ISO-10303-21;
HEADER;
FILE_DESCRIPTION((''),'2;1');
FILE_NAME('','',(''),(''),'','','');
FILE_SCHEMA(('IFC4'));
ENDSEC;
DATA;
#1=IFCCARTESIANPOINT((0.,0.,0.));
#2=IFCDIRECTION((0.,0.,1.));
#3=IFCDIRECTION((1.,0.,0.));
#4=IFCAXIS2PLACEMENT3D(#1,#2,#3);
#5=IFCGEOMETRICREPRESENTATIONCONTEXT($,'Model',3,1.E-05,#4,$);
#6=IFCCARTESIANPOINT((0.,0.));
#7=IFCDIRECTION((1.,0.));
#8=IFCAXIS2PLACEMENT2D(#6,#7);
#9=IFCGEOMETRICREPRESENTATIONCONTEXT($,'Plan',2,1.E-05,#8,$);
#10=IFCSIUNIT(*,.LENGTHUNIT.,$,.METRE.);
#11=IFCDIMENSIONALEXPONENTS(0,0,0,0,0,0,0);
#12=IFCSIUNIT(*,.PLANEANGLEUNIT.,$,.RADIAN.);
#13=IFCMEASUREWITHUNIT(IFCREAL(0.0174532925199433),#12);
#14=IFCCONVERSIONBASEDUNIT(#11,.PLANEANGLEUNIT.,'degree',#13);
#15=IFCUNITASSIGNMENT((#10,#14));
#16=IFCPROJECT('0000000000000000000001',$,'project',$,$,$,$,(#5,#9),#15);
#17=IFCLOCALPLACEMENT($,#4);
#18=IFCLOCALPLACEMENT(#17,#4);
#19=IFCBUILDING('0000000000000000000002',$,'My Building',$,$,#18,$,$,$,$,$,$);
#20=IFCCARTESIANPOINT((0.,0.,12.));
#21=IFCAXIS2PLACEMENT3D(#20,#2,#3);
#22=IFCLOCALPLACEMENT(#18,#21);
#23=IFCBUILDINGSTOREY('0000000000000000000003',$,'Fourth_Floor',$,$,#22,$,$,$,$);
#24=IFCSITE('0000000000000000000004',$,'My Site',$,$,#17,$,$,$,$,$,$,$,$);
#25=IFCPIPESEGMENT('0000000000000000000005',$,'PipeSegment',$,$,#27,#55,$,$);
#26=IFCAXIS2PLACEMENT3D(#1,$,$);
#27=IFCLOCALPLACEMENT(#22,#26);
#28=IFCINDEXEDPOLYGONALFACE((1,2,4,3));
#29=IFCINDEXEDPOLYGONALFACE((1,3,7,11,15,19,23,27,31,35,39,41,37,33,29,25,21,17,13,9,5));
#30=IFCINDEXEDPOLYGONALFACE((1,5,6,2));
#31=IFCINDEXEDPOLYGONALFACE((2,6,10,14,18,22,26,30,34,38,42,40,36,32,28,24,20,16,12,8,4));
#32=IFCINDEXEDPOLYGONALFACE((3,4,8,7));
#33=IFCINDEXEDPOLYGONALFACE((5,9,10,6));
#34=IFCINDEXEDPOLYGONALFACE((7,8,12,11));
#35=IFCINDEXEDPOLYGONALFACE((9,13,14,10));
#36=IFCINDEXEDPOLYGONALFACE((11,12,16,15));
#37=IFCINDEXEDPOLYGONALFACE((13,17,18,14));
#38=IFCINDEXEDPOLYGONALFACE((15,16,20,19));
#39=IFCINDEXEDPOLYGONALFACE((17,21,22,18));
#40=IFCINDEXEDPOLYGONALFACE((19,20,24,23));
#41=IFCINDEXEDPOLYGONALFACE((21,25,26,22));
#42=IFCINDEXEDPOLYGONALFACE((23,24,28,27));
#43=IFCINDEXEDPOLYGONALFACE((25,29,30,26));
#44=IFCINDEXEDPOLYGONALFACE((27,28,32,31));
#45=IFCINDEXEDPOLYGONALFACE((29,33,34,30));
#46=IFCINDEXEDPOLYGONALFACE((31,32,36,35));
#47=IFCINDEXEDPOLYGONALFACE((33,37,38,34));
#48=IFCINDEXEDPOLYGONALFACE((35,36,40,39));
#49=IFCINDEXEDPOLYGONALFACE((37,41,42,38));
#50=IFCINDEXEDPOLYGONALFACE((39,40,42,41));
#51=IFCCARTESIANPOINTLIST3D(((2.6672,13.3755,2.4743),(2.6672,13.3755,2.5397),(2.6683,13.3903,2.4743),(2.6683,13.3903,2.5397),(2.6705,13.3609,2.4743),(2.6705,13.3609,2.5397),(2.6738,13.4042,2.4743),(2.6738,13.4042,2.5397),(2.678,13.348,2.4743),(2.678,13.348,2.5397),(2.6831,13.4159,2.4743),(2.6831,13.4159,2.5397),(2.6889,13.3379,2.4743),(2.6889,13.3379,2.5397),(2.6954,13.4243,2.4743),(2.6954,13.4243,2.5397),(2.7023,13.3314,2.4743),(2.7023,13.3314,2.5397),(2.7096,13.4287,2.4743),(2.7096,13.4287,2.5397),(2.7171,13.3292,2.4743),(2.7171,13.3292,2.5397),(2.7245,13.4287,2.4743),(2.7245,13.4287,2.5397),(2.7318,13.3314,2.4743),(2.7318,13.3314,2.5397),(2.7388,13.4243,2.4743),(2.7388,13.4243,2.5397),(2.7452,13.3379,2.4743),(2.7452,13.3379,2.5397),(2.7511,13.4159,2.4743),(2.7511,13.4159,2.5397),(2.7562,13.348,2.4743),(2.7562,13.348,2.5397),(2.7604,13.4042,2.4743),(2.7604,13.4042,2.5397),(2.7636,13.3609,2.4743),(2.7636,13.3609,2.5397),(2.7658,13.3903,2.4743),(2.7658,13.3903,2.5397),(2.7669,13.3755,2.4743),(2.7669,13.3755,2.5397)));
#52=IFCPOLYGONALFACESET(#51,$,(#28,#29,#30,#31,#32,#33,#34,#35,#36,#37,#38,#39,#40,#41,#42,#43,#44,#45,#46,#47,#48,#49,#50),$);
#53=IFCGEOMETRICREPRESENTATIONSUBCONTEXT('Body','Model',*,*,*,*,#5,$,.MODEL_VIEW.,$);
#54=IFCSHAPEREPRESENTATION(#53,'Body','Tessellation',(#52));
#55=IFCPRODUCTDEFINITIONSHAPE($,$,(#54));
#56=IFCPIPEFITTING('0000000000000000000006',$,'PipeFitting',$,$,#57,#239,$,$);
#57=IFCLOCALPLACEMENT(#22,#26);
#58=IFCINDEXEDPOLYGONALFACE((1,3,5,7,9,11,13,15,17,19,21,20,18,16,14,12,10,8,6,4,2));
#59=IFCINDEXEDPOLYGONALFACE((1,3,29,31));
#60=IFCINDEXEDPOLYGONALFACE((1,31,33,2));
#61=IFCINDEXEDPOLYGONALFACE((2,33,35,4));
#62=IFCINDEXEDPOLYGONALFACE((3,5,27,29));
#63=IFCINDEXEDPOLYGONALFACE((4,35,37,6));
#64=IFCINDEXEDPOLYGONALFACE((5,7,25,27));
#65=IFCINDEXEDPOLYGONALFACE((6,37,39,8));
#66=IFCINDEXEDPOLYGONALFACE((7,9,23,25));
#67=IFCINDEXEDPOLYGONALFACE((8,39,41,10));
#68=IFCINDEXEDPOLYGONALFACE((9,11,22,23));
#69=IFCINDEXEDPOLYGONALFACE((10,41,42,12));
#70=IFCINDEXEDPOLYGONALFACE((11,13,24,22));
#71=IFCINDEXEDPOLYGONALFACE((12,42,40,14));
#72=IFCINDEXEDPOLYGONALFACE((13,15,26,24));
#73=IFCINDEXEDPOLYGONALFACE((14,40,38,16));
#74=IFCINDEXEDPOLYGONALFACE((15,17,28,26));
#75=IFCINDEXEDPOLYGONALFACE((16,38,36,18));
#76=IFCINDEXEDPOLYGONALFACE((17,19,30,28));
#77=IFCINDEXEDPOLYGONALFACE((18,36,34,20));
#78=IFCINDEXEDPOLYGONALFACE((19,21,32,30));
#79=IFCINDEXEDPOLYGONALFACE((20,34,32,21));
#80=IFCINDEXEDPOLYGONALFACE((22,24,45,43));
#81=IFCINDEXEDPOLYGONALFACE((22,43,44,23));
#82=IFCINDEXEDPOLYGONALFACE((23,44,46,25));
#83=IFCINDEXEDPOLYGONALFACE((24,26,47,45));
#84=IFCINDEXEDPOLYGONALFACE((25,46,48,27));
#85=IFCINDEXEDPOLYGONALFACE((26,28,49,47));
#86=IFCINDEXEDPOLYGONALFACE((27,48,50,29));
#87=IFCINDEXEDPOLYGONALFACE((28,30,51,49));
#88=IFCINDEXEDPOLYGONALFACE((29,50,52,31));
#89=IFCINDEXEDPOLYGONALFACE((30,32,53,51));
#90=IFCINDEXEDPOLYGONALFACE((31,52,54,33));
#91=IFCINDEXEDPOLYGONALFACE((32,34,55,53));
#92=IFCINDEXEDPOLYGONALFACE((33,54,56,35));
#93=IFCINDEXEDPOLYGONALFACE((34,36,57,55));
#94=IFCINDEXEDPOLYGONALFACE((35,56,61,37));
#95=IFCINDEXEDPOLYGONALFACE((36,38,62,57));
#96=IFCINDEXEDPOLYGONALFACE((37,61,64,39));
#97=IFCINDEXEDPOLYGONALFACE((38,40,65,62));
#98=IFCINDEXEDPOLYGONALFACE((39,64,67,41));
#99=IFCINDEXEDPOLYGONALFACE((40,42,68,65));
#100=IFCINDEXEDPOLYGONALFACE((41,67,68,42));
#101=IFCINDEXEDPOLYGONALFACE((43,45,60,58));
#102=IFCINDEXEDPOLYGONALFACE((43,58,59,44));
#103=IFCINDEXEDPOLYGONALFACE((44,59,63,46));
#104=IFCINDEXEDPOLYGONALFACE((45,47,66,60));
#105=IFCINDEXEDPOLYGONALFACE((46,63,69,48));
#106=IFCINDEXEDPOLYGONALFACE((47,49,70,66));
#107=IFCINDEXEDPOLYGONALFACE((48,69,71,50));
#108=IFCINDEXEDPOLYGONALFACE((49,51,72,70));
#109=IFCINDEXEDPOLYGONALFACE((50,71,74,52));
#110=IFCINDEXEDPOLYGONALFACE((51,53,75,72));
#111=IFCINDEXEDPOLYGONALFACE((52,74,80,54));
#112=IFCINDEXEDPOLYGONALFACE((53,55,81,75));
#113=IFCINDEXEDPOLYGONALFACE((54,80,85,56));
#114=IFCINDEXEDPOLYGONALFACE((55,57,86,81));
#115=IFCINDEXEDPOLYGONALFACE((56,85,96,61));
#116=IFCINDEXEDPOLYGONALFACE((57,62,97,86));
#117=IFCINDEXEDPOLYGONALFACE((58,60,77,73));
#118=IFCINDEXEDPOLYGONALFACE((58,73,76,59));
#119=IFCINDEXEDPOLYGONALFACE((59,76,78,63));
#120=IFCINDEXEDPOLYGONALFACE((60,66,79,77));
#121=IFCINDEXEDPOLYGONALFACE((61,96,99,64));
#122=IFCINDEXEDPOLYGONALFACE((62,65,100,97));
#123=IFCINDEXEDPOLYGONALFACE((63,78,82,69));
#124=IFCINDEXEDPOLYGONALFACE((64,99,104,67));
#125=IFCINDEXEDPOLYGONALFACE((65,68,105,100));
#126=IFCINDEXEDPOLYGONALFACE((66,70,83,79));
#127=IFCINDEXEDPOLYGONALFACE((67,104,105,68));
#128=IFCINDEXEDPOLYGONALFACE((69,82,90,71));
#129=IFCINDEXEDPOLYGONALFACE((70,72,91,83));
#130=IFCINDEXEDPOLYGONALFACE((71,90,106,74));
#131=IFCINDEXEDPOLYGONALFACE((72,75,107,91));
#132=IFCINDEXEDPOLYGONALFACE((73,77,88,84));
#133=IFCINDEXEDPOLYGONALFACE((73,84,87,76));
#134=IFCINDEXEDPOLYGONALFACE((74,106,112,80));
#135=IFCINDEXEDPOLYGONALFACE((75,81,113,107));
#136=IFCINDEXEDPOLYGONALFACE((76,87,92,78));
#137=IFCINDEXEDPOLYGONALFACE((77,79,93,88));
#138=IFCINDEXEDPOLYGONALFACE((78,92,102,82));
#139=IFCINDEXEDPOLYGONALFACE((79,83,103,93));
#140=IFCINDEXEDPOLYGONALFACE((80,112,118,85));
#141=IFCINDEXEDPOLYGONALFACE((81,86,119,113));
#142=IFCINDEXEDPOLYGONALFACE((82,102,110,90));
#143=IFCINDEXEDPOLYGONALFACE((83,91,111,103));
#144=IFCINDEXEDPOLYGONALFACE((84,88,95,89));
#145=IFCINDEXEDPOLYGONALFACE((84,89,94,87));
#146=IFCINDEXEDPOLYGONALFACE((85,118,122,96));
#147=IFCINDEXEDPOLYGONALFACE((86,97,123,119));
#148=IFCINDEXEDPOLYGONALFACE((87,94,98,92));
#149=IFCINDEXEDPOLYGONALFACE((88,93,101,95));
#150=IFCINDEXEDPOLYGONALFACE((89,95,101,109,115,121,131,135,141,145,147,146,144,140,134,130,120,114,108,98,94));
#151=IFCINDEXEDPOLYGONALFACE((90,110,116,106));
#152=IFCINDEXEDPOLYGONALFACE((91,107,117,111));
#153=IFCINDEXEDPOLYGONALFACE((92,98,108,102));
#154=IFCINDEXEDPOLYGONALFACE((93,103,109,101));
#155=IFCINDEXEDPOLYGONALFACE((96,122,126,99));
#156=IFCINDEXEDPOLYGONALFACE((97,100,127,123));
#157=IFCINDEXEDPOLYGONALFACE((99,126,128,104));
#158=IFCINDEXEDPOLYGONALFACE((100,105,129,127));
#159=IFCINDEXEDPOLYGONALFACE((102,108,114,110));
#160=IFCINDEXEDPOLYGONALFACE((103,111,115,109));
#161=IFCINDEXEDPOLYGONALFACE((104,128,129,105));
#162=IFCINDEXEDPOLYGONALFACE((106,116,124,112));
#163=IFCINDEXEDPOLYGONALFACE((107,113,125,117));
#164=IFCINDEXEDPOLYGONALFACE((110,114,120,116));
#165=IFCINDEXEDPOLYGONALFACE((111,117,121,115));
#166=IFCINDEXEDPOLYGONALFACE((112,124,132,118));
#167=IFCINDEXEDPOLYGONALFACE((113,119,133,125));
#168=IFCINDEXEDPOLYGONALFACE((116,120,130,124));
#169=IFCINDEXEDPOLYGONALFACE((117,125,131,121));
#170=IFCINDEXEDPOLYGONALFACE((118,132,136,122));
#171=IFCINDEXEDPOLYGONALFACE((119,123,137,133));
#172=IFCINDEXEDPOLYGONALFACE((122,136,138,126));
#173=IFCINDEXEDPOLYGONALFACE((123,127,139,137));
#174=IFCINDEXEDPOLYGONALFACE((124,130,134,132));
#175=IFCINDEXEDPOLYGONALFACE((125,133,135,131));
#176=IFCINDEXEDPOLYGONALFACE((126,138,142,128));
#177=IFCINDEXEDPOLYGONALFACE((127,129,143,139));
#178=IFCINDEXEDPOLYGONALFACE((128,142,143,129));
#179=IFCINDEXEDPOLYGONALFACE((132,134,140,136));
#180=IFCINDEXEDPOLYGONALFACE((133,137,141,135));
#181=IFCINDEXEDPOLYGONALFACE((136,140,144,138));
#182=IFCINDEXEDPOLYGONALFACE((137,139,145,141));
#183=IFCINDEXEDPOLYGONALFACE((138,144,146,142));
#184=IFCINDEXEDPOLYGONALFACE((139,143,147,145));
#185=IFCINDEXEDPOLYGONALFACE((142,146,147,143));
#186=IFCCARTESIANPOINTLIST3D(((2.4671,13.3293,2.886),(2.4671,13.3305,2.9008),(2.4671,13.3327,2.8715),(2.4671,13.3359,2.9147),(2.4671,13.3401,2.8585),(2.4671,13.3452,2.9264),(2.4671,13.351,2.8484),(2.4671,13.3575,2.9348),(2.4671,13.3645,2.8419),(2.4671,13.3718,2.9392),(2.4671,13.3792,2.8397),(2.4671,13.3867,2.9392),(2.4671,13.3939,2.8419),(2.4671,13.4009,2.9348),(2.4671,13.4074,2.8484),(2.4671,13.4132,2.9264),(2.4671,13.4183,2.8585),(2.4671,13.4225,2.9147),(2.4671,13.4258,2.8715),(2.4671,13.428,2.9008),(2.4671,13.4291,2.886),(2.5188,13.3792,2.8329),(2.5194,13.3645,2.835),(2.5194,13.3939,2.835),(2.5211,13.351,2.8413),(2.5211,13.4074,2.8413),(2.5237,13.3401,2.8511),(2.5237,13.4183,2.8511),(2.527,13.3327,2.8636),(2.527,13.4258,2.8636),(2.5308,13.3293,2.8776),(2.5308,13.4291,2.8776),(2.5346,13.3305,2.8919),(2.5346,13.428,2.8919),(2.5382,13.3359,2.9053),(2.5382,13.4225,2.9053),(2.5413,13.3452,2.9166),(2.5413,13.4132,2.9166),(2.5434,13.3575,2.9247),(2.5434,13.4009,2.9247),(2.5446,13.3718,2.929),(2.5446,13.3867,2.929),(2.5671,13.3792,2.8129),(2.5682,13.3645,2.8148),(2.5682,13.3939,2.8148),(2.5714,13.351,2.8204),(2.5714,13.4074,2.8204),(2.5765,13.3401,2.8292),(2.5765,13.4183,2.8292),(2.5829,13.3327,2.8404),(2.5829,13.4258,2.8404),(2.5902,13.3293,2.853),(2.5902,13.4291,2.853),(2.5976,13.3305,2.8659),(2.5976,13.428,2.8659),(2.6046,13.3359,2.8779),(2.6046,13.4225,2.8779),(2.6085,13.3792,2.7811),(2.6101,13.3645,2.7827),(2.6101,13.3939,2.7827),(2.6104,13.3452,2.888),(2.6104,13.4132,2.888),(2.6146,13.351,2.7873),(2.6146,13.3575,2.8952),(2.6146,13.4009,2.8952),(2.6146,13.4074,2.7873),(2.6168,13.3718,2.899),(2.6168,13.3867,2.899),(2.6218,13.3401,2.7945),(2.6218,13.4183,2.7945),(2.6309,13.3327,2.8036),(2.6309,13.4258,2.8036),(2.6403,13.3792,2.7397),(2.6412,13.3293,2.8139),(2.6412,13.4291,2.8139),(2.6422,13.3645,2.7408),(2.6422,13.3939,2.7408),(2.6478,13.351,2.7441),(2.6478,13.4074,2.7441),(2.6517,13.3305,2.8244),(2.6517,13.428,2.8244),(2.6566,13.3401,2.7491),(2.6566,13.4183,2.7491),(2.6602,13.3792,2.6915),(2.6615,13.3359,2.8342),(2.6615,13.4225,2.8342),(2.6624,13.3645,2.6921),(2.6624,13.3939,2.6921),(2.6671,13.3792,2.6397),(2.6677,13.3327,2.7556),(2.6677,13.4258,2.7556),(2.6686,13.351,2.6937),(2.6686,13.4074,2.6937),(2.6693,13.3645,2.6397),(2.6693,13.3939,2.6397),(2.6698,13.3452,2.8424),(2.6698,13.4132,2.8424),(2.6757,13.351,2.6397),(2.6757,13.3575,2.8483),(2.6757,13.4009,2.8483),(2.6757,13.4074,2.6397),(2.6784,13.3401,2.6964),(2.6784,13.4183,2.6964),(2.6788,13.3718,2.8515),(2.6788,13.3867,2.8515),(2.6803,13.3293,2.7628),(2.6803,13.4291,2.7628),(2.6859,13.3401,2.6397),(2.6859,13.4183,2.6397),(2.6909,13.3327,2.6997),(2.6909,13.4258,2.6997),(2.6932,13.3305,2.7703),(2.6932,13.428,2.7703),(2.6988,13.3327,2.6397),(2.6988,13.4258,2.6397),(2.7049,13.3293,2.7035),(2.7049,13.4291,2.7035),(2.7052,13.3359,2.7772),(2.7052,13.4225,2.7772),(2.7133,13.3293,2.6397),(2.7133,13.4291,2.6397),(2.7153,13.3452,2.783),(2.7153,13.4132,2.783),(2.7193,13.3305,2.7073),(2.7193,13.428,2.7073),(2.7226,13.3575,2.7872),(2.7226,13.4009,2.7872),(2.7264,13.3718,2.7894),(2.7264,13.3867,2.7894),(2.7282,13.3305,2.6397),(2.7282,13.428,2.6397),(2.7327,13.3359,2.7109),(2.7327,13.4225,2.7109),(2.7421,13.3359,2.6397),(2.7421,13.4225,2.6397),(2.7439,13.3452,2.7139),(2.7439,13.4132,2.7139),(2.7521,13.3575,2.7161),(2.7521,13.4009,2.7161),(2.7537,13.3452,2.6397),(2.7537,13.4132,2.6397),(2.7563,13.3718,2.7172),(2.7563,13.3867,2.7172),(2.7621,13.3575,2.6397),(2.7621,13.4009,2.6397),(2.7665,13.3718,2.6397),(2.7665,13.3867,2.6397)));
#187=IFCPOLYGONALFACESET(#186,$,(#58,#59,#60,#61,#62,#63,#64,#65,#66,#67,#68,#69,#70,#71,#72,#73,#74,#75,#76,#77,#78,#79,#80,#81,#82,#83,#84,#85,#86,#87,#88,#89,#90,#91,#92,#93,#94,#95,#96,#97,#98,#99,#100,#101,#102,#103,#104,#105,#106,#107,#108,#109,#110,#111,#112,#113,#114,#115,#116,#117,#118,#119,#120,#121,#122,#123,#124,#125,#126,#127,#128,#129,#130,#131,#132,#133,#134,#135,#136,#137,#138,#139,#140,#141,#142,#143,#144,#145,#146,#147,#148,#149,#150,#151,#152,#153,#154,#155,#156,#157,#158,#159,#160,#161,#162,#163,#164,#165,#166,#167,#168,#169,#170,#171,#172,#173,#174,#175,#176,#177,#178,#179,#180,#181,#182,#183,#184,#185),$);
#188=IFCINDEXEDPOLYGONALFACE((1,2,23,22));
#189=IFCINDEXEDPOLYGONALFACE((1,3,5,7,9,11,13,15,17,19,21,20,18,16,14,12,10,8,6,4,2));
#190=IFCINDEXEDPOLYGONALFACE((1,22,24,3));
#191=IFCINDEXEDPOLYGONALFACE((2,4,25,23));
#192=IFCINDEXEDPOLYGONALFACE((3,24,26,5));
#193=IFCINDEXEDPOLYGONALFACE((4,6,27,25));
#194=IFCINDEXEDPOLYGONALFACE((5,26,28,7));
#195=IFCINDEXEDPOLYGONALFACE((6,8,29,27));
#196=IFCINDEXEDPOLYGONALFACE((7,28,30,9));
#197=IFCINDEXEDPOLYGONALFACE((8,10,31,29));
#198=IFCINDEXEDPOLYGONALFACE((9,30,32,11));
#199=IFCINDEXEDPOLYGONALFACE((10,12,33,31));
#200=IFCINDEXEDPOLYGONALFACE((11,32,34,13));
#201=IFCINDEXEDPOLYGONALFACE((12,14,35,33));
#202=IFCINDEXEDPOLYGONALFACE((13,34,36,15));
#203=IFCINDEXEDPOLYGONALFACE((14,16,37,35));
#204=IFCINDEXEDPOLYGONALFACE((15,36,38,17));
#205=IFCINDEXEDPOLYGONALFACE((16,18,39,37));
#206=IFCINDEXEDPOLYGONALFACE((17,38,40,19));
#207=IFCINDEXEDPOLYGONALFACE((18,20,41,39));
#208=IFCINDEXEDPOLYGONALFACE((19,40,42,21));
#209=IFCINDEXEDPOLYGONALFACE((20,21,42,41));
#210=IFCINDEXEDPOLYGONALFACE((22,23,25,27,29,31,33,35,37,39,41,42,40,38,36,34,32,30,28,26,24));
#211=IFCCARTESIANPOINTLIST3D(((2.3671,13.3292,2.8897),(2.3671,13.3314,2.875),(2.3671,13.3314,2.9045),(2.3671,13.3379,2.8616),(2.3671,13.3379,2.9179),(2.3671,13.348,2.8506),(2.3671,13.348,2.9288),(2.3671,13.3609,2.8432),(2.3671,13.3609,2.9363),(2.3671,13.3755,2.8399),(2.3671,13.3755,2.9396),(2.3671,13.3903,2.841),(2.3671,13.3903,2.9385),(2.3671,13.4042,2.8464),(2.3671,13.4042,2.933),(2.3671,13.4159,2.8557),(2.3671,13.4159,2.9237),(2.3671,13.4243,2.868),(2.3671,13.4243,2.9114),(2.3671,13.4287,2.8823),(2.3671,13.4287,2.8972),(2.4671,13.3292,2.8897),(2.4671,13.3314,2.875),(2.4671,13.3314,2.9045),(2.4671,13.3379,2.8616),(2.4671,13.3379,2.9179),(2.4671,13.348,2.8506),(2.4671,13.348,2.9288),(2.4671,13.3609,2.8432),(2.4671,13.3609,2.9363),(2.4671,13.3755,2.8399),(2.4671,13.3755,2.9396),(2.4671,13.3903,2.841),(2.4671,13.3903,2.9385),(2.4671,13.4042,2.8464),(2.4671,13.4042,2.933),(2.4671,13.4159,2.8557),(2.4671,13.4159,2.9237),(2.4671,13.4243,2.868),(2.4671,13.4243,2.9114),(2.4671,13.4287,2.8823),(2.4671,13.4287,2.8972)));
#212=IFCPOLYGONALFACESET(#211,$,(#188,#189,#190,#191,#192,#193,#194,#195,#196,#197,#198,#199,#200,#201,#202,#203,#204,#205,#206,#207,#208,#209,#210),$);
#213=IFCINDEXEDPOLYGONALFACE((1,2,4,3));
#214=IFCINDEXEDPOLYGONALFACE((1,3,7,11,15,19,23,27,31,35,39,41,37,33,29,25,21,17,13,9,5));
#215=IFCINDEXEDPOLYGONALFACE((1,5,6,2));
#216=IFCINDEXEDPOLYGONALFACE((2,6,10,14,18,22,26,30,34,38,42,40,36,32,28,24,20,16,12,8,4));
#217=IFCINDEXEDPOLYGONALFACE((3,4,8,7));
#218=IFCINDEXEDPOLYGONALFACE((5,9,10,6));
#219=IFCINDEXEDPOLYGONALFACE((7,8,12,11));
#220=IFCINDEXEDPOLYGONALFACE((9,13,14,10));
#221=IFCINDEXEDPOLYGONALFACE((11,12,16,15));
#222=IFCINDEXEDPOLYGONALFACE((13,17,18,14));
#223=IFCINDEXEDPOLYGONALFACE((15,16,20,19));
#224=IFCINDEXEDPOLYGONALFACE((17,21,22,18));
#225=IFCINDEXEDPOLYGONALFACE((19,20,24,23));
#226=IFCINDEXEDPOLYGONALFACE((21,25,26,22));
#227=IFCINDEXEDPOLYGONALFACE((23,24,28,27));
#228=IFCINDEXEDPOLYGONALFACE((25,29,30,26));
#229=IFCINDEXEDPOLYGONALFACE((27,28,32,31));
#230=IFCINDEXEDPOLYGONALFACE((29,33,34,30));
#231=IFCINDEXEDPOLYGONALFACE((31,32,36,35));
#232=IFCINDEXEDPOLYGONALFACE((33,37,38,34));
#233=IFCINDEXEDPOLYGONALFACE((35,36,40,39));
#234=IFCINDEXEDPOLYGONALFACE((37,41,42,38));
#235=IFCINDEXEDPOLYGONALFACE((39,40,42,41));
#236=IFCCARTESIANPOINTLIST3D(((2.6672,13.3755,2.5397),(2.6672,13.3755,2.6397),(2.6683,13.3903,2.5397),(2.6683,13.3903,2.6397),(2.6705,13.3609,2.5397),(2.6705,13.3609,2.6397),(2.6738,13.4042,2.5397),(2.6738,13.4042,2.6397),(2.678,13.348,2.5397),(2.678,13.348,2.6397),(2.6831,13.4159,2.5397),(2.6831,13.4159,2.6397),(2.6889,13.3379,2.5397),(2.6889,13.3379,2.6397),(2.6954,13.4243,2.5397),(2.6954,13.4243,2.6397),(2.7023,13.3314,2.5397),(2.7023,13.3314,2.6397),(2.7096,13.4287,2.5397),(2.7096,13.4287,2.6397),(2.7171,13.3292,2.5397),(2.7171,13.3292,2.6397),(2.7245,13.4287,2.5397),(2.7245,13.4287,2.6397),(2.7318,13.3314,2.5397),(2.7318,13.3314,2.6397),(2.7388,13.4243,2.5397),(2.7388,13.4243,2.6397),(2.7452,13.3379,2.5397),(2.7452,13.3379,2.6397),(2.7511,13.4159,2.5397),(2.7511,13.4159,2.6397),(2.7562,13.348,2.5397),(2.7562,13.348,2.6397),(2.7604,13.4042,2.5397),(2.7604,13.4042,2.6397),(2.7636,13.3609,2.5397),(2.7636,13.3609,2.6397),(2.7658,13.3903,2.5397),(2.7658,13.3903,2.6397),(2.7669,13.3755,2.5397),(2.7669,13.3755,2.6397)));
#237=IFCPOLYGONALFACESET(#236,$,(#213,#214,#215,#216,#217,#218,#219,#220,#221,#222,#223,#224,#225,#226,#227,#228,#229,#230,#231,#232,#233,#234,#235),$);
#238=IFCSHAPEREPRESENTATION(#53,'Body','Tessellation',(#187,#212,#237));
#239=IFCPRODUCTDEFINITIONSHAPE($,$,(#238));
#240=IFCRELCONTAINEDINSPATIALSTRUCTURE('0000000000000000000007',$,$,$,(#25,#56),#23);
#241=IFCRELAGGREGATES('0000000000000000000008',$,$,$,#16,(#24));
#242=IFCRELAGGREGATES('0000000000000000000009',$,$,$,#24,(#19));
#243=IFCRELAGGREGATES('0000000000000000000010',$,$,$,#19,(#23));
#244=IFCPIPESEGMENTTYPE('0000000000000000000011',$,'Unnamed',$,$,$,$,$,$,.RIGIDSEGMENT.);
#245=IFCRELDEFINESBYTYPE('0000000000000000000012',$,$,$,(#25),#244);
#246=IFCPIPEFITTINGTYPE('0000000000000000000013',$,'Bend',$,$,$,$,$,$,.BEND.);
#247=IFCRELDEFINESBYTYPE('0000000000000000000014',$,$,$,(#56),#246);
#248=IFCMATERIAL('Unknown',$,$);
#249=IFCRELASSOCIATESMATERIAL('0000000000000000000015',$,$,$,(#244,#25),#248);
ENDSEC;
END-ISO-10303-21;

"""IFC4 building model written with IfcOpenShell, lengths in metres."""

from ifc_helpers import new_model, entity, si_unit, converted_unit, frame, origin_with_axes, origin_2d_with_axis, place, context, subcontext, project, spatial, circle, extrude, source, transform, mapped, material, material_profile, profile_set, profile_usage, type_object, type_shapes, element, save


model = new_model("IFC4")

# Units and contexts
model_context = context("Model", 3, precision=1e-05, world=origin_with_axes())
plan_context = context("Plan", 2, precision=1e-05, world=origin_2d_with_axis())
body_context_1 = subcontext(model_context, "Body", "Model", "MODEL_VIEW")
ifc_project = project(units=[si_unit("LENGTHUNIT", "METRE"), converted_unit("PLANEANGLEUNIT", "degree", entity("IfcReal", 0.0174532925199433), si_unit("PLANEANGLEUNIT", "RADIAN"), dimensions=[0, 0, 0, 0, 0, 0, 0])], contexts=[model_context, plan_context])

# Site, building, storey
site_placement = place(None, origin_with_axes())
site = spatial("IfcSite", under=ifc_project, at=site_placement, Name="My Site")
building_placement = place(site_placement, origin_with_axes())
building = spatial("IfcBuilding", under=site, at=building_placement, Name="My Building")
storey_placement = place(building_placement, frame((0.0, 0.0, 12.0), z_axis=(0.0, 0.0, 1.0), x_axis=(1.0, 0.0, 0.0)))
storey = spatial("IfcBuildingStorey", under=building, at=storey_placement, Name="Fourth_Floor")

# Shared definitions
ifc_material = material(Name="Unknown")

# Pipe segment
ifc_material_profile_1 = material_profile(ifc_material, circle(Radius=0.05))
ifc_profile_set_1 = profile_set([ifc_material_profile_1])
pipe_segment_type = type_object("IfcPipeSegmentType", Name="Unnamed", PredefinedType="RIGIDSEGMENT", material=ifc_profile_set_1)
ifc_profile_usage_1 = profile_usage(ifc_profile_set_1, cardinal=5)
pipe_segment_1_placement = place(storey_placement, frame((2.7171, 13.3792, 2.4743), z_axis=(0.0, 0.0, 1.0), x_axis=(0.000001, -1.0, 0.0)))
element("IfcPipeSegment", 1, at=pipe_segment_1_placement, inside=storey, type_object=pipe_segment_type, material=ifc_profile_usage_1, Name="PipeSegment", context=body_context_1, shape_type="SweptSolid", body=[
    extrude(circle(Radius=0.05), origin_with_axes(), (0.0, 0.0, 1.0), 0.0654),
])

# Pipe fitting
pipe_fitting_type = type_object("IfcPipeFittingType", Name="Bend", PredefinedType="BEND")
shared_shape_1 = source(origin_with_axes(), body_context_1, "Body", "SolidModel", [
    entity("IfcSweptDiskSolid", entity("IfcIndexedPolyCurve", entity("IfcCartesianPointList3D", [[0.0, 0.0, -0.1], [0.0, -0.0732, -0.2768], [0.0, -0.25, -0.35]]), [entity("IfcArcIndex", [1, 2, 3])]), 0.05),
    extrude(circle(Radius=0.05), origin_with_axes(), (0.0, 0.0, -1.0), 0.1),
    extrude(circle(Radius=0.05), frame((0.0, -0.25, -0.35), z_axis=(0.0, -1.0, 0.0), x_axis=(1.0, 0.0, 0.0)), (0.0, 0.0, 1.0), 0.1),
])
type_shapes(pipe_fitting_type, [shared_shape_1])
pipe_fitting_placement = place(storey_placement, frame((2.3671, 13.3792, 2.8897), z_axis=(-1.0, 0.0, 0.0), x_axis=(0.0, -1.0, 0.0)))
element("IfcPipeFitting", 2, at=pipe_fitting_placement, inside=storey, type_object=pipe_fitting_type, Name="PipeFitting", context=body_context_1, shape_type="MappedRepresentation", body=[
    mapped(shared_shape_1, transform((0.0, 0.0, 0.0), x_axis=(1.0, 0.0, 0.0), y_axis=(0.0, 1.0, 0.0), z_axis=(0.0, 0.0, 1.0), scale=1.0)),
])

save(model, "model.ifc")
